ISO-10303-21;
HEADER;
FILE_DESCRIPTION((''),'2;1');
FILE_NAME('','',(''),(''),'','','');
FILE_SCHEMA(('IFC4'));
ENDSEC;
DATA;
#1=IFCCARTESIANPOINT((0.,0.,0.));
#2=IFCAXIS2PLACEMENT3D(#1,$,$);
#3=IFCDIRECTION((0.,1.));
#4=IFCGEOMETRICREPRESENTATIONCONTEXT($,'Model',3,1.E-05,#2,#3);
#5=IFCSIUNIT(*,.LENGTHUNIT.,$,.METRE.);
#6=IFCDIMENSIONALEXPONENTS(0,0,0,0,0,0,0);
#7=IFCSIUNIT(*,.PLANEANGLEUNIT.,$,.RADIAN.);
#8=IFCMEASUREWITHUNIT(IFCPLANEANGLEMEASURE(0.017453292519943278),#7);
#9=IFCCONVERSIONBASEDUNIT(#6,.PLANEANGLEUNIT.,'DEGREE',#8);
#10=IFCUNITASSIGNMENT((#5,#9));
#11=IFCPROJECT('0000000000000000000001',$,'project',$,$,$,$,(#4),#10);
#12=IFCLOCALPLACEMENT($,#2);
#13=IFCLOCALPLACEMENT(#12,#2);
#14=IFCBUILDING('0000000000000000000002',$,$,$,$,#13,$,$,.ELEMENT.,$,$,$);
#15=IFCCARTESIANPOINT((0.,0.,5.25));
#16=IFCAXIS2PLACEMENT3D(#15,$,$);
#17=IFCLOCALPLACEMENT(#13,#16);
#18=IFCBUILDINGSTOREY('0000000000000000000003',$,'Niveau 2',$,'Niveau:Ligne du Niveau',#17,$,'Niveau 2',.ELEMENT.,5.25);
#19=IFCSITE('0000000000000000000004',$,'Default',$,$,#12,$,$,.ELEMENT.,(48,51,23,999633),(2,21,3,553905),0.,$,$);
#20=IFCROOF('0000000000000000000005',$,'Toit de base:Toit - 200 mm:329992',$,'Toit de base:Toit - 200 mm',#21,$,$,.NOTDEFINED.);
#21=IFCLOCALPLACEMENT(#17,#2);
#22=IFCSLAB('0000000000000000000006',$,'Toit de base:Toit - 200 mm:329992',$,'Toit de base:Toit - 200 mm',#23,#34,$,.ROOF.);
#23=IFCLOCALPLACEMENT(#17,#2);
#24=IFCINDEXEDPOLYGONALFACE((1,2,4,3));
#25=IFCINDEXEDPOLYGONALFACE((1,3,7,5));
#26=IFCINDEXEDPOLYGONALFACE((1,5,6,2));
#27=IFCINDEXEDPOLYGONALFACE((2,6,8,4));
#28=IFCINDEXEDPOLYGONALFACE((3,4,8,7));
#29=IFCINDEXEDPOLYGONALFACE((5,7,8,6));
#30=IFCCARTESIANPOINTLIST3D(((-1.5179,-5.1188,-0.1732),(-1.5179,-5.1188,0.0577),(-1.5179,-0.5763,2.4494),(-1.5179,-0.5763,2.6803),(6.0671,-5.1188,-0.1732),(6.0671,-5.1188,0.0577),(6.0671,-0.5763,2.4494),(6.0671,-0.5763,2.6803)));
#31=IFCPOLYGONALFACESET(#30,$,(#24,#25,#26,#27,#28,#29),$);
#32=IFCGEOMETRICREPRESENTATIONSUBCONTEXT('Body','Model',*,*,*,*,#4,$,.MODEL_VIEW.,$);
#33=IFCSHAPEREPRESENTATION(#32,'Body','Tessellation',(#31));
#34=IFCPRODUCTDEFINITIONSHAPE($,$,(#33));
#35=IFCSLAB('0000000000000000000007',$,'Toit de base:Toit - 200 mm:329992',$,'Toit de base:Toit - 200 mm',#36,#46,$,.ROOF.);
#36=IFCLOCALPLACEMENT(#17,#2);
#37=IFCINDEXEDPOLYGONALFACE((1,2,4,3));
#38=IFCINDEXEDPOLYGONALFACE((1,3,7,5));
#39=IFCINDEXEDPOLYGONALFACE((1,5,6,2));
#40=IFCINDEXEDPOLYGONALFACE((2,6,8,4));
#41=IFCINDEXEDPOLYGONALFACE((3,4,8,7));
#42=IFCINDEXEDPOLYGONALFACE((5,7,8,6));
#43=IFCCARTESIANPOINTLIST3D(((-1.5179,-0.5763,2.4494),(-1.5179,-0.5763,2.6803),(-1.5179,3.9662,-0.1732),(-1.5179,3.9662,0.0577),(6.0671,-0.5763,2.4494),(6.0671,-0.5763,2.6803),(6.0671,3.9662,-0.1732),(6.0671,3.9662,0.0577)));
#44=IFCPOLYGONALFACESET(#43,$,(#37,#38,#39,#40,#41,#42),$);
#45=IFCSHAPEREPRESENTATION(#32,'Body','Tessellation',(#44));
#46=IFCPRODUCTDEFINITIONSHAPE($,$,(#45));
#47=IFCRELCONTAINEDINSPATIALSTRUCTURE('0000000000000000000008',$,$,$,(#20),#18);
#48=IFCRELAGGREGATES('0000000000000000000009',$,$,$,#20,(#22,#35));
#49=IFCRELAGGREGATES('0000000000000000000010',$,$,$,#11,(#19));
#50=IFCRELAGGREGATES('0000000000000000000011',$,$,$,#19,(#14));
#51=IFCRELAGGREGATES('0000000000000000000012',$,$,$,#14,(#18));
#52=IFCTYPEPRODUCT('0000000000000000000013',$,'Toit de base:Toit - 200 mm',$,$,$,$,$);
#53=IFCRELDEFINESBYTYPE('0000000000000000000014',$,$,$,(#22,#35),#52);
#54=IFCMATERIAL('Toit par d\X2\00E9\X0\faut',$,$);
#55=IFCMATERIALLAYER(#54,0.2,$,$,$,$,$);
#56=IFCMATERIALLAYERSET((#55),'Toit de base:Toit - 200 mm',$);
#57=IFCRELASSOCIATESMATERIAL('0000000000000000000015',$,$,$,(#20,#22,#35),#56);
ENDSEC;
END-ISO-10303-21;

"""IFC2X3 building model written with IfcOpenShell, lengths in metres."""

from ifc_helpers import new_model, entity, si_unit, converted_unit, direction, frame, frame_2d, origin, place, context, subcontext, project, spatial, rectangle, extrude, material, layer, layer_set, type_object, element, aggregate, save


model = new_model("IFC2X3")

# Units and contexts
model_context = context("Model", 3, precision=1e-05, world=origin(), true_north=direction((0.0, 1.0)))
body_context = subcontext(model_context, "Body", "Model", "MODEL_VIEW")
ifc_project = project(units=[si_unit("LENGTHUNIT", "METRE"), converted_unit("PLANEANGLEUNIT", "DEGREE", entity("IfcPlaneAngleMeasure", 0.017453292519943278), si_unit("PLANEANGLEUNIT", "RADIAN"), dimensions=[0, 0, 0, 0, 0, 0, 0])], contexts=[model_context])

# Site, building, storey
site_placement = place(None, origin())
site = spatial("IfcSite", under=ifc_project, at=site_placement, Name="Default", CompositionType="ELEMENT", RefLatitude=(48, 51, 23, 999633), RefLongitude=(2, 21, 3, 553905), RefElevation=0.0)
building_placement = place(site_placement, origin())
building = spatial("IfcBuilding", under=site, at=building_placement, CompositionType="ELEMENT")
storey_placement = place(building_placement, frame((0.0, 0.0, 5.25)))
storey = spatial("IfcBuildingStorey", under=building, at=storey_placement, Name="Niveau 2", ObjectType="Niveau:Ligne du Niveau", LongName="Niveau 2", CompositionType="ELEMENT", Elevation=5.25)

# Roof, slabs
ifc_material = material(Name="Toit par défaut")
ifc_layer = layer(ifc_material, 0.2)
ifc_layer_set = layer_set([ifc_layer], Name="Toit de base:Toit - 200 mm")
roof_placement = place(storey_placement, frame((-1.5179, -5.1188, -0.1732)))
roof = element("IfcRoof", 1, at=roof_placement, inside=storey, material=ifc_layer_set, Name="Toit de base:Toit - 200 mm:329992", ObjectType="Toit de base:Toit - 200 mm", ShapeType="NOTDEFINED")
type_product = type_object("IfcTypeProduct", Name="Toit de base:Toit - 200 mm")
slab_1_placement = place(roof_placement, origin())
slab_1 = element("IfcSlab", 2, at=slab_1_placement, type_object=type_product, material=ifc_layer_set, Name="Toit de base:Toit - 200 mm:329992", ObjectType="Toit de base:Toit - 200 mm", PredefinedType="ROOF", context=body_context, shape_type="SweptSolid", body=[
    extrude(rectangle(XDim=5.2452, YDim=7.585, at=frame_2d((0.0, 0.0), x_axis=(0.0, 1.0))), frame((3.7925, 2.2713, 1.3113), z_axis=(0.0, -0.5, 0.866025), x_axis=(1.0, 0.0, 0.0)), (0.0, 0.5, 0.866025), 0.2309),
])
slab_2_placement = place(roof_placement, origin())
slab_2 = element("IfcSlab", 3, at=slab_2_placement, type_object=type_product, material=ifc_layer_set, Name="Toit de base:Toit - 200 mm:329992", ObjectType="Toit de base:Toit - 200 mm", PredefinedType="ROOF", context=body_context, shape_type="SweptSolid", body=[
    extrude(rectangle(XDim=7.585, YDim=5.2452, at=frame_2d((0.0, 0.0), x_axis=(1.0, 0.0))), frame((3.7925, 6.8138, 1.3113), z_axis=(0.0, 0.5, 0.866025), x_axis=(1.0, 0.0, 0.0)), (0.0, -0.5, 0.866025), 0.2309),
])
aggregate(roof, [slab_1, slab_2])

save(model, "model.ifc")
